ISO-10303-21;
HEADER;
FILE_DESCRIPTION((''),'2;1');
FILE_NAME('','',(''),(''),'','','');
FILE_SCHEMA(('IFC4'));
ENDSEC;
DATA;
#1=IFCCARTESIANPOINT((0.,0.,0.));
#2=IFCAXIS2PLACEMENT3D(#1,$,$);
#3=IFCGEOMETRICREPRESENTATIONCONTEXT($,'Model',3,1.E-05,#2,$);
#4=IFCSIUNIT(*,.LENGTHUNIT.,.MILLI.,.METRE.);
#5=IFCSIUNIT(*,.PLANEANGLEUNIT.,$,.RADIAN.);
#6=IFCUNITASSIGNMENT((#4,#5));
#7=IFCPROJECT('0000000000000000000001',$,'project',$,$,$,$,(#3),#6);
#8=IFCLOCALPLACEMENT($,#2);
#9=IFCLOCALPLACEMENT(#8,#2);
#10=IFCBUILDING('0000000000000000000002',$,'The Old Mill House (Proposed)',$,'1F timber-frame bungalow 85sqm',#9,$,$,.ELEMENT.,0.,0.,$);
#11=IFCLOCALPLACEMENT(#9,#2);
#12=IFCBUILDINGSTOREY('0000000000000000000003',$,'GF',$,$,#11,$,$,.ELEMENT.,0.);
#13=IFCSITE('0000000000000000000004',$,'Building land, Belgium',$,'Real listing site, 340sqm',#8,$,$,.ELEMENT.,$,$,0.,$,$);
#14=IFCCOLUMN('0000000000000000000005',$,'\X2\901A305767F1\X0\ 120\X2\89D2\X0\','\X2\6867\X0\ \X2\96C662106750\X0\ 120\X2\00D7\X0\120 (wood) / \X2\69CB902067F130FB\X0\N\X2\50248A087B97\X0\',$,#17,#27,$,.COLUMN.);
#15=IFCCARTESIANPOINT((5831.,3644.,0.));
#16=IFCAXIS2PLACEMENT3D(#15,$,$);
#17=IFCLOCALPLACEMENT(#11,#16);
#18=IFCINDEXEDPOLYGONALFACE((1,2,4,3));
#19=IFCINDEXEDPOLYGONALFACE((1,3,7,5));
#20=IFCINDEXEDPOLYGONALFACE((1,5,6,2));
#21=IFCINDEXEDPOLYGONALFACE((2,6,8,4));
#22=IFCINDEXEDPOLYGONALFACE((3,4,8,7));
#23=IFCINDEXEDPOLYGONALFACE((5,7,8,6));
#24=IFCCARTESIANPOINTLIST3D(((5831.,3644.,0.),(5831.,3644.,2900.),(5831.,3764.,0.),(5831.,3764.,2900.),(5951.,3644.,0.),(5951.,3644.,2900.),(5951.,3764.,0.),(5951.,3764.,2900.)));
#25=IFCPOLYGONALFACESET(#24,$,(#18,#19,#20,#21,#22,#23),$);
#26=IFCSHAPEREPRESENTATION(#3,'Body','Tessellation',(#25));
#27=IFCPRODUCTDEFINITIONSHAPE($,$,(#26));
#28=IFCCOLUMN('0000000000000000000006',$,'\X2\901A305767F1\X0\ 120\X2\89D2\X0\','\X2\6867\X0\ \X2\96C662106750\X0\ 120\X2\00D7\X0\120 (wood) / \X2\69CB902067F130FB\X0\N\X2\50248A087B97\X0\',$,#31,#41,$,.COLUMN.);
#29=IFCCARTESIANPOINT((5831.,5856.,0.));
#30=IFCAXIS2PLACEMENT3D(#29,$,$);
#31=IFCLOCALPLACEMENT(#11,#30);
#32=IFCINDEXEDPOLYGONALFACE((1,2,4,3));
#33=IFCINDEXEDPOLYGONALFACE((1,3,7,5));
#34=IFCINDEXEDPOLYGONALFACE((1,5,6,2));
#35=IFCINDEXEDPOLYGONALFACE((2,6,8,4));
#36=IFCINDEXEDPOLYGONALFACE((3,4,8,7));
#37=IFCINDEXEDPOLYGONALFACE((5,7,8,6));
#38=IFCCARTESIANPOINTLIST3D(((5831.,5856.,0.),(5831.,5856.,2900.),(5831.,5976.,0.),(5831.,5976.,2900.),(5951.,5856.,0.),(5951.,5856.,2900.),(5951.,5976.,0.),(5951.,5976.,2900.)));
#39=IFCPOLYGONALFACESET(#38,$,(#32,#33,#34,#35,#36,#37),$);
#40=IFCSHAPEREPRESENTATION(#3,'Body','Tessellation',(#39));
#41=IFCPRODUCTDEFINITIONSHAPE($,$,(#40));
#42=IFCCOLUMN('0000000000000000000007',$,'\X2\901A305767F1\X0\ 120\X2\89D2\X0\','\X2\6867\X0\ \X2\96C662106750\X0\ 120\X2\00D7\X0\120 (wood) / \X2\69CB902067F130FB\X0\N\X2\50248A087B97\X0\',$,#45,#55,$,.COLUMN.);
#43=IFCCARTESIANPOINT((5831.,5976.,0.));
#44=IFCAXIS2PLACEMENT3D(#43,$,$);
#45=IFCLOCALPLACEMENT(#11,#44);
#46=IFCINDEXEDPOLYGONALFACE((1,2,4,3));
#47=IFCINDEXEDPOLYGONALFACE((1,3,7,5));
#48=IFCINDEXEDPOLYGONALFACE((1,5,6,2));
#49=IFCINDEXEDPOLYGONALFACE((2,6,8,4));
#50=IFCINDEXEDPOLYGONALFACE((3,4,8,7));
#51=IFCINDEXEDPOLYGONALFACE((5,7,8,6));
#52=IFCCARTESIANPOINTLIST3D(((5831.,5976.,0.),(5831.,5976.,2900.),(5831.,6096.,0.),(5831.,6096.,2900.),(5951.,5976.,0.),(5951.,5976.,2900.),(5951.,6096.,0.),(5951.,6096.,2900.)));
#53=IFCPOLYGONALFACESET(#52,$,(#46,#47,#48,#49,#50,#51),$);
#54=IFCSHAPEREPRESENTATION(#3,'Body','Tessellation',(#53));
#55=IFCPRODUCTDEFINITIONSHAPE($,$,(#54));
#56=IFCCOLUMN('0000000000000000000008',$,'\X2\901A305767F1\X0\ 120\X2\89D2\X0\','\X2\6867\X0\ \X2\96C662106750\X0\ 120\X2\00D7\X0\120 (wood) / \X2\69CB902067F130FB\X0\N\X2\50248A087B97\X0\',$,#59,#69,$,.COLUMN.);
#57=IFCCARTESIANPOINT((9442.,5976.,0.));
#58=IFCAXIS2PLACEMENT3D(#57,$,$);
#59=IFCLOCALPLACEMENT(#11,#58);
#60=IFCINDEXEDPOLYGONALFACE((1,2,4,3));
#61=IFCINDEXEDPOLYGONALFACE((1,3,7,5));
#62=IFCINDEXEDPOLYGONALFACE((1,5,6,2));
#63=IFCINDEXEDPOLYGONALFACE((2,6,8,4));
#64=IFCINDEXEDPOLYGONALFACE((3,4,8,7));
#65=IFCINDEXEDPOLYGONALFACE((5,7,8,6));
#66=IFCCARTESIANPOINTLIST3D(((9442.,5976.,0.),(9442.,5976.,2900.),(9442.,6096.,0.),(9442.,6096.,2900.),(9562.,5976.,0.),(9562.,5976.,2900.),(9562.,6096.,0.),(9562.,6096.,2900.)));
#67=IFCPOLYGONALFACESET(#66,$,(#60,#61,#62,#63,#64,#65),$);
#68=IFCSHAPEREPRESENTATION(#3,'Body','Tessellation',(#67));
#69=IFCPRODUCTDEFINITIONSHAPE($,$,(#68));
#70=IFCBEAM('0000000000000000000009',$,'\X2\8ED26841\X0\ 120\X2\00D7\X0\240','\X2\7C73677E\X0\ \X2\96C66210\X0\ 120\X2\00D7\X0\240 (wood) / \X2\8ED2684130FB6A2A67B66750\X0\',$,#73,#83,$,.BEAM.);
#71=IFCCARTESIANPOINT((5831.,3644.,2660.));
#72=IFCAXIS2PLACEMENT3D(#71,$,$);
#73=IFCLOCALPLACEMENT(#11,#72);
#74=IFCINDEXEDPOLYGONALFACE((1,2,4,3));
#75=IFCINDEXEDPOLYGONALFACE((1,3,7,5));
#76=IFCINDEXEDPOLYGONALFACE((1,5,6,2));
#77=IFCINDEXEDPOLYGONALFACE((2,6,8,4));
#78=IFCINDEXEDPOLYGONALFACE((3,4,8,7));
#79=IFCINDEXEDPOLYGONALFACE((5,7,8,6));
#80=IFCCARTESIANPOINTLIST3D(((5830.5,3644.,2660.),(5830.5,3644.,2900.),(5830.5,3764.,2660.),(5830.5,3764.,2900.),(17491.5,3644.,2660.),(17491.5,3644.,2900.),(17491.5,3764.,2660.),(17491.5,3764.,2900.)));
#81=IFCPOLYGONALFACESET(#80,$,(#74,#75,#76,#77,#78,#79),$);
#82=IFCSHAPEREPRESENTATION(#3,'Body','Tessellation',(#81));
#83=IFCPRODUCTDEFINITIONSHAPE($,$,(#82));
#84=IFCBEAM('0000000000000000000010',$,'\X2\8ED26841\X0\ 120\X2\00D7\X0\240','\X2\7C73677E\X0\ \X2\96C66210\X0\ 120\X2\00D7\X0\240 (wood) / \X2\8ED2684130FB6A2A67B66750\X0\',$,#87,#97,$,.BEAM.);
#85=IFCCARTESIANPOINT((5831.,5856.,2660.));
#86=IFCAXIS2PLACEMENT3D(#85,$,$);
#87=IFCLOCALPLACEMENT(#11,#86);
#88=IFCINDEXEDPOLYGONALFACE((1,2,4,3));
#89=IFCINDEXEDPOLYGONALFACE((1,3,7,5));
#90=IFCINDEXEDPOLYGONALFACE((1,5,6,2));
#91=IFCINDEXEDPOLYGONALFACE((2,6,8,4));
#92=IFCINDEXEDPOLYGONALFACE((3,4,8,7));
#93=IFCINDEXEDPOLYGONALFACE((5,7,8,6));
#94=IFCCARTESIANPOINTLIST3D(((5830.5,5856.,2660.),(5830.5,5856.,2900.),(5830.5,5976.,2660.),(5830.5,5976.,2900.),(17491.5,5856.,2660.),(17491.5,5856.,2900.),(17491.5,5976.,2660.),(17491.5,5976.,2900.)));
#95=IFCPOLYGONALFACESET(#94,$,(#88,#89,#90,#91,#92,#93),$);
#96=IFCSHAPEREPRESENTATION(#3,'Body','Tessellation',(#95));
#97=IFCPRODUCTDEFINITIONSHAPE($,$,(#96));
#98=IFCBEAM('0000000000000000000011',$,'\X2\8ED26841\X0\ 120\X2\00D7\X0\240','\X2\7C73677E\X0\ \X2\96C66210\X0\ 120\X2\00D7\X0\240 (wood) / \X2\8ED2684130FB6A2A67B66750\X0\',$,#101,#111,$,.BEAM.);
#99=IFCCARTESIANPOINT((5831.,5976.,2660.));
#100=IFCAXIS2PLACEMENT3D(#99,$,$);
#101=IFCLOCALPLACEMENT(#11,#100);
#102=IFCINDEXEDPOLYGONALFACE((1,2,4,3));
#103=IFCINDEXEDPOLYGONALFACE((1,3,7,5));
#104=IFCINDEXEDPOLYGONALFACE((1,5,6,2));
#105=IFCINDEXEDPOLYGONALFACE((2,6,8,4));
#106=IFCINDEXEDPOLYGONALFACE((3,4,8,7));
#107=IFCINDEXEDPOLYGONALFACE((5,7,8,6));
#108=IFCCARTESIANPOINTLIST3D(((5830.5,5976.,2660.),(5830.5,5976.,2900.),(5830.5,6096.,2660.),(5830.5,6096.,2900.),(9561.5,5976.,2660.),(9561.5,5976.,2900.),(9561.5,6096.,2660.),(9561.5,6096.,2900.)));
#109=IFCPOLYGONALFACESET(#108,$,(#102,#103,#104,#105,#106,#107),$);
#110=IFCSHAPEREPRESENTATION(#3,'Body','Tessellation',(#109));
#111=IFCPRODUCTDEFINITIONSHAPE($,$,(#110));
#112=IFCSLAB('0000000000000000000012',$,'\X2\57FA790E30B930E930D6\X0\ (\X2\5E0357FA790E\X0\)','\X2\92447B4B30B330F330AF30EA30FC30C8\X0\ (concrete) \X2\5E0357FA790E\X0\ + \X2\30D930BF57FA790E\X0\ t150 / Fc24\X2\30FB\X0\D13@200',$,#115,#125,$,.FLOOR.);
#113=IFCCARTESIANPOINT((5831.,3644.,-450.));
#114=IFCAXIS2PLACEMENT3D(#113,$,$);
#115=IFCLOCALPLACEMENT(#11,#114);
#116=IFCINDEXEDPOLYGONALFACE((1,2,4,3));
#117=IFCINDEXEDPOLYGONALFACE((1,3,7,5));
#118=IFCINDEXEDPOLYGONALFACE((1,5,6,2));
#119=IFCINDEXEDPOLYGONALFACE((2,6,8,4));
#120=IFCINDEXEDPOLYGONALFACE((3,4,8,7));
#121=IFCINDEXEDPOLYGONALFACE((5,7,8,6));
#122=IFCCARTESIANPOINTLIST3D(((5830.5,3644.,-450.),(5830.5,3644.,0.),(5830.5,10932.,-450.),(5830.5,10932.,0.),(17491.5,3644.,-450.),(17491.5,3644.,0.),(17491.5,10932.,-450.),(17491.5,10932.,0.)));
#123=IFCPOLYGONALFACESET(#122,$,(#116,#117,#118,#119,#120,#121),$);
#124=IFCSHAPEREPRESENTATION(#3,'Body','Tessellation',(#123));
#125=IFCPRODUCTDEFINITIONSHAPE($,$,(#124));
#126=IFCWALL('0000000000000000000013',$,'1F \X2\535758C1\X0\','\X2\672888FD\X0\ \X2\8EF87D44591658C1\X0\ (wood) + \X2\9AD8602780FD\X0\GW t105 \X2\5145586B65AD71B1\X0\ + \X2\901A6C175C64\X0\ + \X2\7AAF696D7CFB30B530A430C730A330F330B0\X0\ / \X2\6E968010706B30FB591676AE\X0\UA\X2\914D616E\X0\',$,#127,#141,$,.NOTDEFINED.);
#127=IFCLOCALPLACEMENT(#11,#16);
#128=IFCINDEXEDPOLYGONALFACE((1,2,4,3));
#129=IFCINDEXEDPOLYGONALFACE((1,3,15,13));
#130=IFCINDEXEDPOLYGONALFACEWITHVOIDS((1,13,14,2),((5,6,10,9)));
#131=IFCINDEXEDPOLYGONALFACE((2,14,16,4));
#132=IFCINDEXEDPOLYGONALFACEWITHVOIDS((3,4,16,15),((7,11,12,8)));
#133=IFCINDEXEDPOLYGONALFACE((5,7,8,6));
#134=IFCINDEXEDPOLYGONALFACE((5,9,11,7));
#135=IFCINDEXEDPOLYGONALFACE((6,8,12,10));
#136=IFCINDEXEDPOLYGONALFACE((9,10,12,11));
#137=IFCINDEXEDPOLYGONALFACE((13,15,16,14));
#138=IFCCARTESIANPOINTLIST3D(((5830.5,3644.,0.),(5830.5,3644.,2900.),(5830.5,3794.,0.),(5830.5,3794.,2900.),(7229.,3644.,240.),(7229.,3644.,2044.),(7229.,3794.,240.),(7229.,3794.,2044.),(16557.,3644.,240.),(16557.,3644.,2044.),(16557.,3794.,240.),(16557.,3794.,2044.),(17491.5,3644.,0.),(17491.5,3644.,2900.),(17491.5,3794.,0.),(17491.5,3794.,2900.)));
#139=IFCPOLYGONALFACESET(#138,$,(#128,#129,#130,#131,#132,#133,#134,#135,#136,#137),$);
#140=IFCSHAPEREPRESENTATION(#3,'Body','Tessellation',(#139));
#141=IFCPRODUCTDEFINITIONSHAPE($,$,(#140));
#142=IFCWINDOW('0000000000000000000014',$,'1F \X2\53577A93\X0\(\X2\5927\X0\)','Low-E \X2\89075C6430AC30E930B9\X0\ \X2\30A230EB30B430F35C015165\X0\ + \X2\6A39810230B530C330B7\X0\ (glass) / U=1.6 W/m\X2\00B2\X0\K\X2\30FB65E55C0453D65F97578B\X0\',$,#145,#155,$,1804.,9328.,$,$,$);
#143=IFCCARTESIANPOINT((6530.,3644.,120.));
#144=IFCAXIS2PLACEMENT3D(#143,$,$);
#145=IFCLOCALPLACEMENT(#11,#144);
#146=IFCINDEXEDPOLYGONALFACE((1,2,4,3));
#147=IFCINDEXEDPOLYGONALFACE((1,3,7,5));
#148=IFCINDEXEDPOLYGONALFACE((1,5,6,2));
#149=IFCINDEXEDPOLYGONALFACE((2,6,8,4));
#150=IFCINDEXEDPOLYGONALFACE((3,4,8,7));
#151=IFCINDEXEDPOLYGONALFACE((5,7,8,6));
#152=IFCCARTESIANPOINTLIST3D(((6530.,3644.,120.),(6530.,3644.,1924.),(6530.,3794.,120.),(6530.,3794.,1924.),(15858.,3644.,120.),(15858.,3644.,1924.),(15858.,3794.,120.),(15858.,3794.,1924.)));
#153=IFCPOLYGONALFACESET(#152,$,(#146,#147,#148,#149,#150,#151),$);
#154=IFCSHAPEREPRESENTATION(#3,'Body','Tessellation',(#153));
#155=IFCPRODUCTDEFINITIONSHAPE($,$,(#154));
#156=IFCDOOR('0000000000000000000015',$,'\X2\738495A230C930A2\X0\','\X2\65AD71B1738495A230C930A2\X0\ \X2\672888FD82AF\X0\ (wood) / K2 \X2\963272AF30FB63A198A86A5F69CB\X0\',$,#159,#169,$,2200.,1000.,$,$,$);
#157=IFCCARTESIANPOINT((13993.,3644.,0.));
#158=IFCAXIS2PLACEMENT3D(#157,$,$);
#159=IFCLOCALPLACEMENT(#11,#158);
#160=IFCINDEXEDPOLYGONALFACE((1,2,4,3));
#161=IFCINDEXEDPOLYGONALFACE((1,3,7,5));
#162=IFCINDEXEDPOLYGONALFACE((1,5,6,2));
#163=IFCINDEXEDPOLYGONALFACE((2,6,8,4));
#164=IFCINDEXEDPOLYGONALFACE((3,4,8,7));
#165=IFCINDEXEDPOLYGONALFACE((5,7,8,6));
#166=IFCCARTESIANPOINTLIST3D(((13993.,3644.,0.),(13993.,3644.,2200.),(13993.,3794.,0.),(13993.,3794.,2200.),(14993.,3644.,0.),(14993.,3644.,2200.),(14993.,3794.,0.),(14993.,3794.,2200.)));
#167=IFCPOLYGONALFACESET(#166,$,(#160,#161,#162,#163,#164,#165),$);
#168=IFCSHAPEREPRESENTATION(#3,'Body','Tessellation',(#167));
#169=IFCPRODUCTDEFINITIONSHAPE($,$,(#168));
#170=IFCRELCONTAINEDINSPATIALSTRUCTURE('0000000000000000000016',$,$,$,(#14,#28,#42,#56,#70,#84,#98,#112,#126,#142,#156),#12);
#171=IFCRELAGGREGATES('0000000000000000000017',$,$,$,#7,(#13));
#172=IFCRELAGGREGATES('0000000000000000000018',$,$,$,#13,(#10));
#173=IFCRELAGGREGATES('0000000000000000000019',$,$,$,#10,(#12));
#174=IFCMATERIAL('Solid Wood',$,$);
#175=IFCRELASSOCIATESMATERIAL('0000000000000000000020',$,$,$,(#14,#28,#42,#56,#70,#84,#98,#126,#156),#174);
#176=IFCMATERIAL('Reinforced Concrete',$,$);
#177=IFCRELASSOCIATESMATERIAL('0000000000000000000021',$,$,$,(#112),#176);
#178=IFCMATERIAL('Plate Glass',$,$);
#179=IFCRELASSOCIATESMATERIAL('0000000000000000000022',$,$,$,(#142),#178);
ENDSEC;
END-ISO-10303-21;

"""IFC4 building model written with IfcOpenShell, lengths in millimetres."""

from ifc_helpers import new_model, si_unit, frame, frame_2d, origin, place, context, project, spatial, rectangle, extrude, material, element, fill, save


model = new_model("IFC4")

# Units and contexts
model_context = context("Model", 3, precision=1e-05, world=origin())
ifc_project = project(units=[si_unit("LENGTHUNIT", "METRE", prefix="MILLI"), si_unit("PLANEANGLEUNIT", "RADIAN")], contexts=[model_context])

# Site, building, storey
site_placement = place(None, origin())
site = spatial("IfcSite", under=ifc_project, at=site_placement, Name="Building land, Belgium", ObjectType="Real listing site, 340sqm", CompositionType="ELEMENT", RefElevation=0.0)
building_placement = place(site_placement, origin())
building = spatial("IfcBuilding", under=site, at=building_placement, Name="The Old Mill House (Proposed)", ObjectType="1F timber-frame bungalow 85sqm", CompositionType="ELEMENT", ElevationOfRefHeight=0.0, ElevationOfTerrain=0.0)
storey_placement = place(building_placement, origin())
storey = spatial("IfcBuildingStorey", under=building, at=storey_placement, Name="GF", CompositionType="ELEMENT", Elevation=0.0)

# Columns
ifc_material_1 = material(Name="Solid Wood")
column_1_placement = place(storey_placement, frame((5831.0, 3644.0, 0.0)))
element("IfcColumn", 1, at=column_1_placement, inside=storey, material=ifc_material_1, Name="通し柱 120角", Description="桧 集成材 120×120 (wood) / 構造柱・N値計算", PredefinedType="COLUMN", context=model_context, shape_type="SweptSolid", body=[
    extrude(rectangle(XDim=120.0, YDim=120.0, at=frame_2d((60.0, 60.0))), frame((5831.0, 3644.0, 0.0)), (0.0, 0.0, 1.0), 2900.0),
])
column_2_placement = place(storey_placement, frame((5831.0, 5856.0, 0.0)))
element("IfcColumn", 2, at=column_2_placement, inside=storey, material=ifc_material_1, Name="通し柱 120角", Description="桧 集成材 120×120 (wood) / 構造柱・N値計算", PredefinedType="COLUMN", context=model_context, shape_type="SweptSolid", body=[
    extrude(rectangle(XDim=120.0, YDim=120.0, at=frame_2d((60.0, 60.0))), frame((5831.0, 5856.0, 0.0)), (0.0, 0.0, 1.0), 2900.0),
])
column_3_placement = place(storey_placement, frame((5831.0, 5976.0, 0.0)))
element("IfcColumn", 3, at=column_3_placement, inside=storey, material=ifc_material_1, Name="通し柱 120角", Description="桧 集成材 120×120 (wood) / 構造柱・N値計算", PredefinedType="COLUMN", context=model_context, shape_type="SweptSolid", body=[
    extrude(rectangle(XDim=120.0, YDim=120.0, at=frame_2d((60.0, 60.0))), frame((5831.0, 5976.0, 0.0)), (0.0, 0.0, 1.0), 2900.0),
])
column_4_placement = place(storey_placement, frame((9442.0, 5976.0, 0.0)))
element("IfcColumn", 4, at=column_4_placement, inside=storey, material=ifc_material_1, Name="通し柱 120角", Description="桧 集成材 120×120 (wood) / 構造柱・N値計算", PredefinedType="COLUMN", context=model_context, shape_type="SweptSolid", body=[
    extrude(rectangle(XDim=120.0, YDim=120.0, at=frame_2d((60.0, 60.0))), frame((9442.0, 5976.0, 0.0)), (0.0, 0.0, 1.0), 2900.0),
])

# Beams
beam_1_placement = place(storey_placement, frame((5831.0, 3644.0, 2660.0)))
element("IfcBeam", 5, at=beam_1_placement, inside=storey, material=ifc_material_1, Name="軒桁 120×240", Description="米松 集成 120×240 (wood) / 軒桁・横架材", PredefinedType="BEAM", context=model_context, shape_type="SweptSolid", body=[
    extrude(rectangle(XDim=11661.0, YDim=120.0, at=frame_2d((5830.0, 60.0))), frame((5831.0, 3644.0, 2660.0)), (0.0, 0.0, 1.0), 240.0),
])
beam_2_placement = place(storey_placement, frame((5831.0, 5856.0, 2660.0)))
element("IfcBeam", 6, at=beam_2_placement, inside=storey, material=ifc_material_1, Name="軒桁 120×240", Description="米松 集成 120×240 (wood) / 軒桁・横架材", PredefinedType="BEAM", context=model_context, shape_type="SweptSolid", body=[
    extrude(rectangle(XDim=11661.0, YDim=120.0, at=frame_2d((5830.0, 60.0))), frame((5831.0, 5856.0, 2660.0)), (0.0, 0.0, 1.0), 240.0),
])
beam_3_placement = place(storey_placement, frame((5831.0, 5976.0, 2660.0)))
element("IfcBeam", 7, at=beam_3_placement, inside=storey, material=ifc_material_1, Name="軒桁 120×240", Description="米松 集成 120×240 (wood) / 軒桁・横架材", PredefinedType="BEAM", context=model_context, shape_type="SweptSolid", body=[
    extrude(rectangle(XDim=3731.0, YDim=120.0, at=frame_2d((1865.0, 60.0))), frame((5831.0, 5976.0, 2660.0)), (0.0, 0.0, 1.0), 240.0),
])

# Slab
ifc_material_2 = material(Name="Reinforced Concrete")
slab_1_placement = place(storey_placement, frame((5831.0, 3644.0, -450.0)))
element("IfcSlab", 8, at=slab_1_placement, inside=storey, material=ifc_material_2, Name="基礎スラブ (布基礎)", Description="鉄筋コンクリート (concrete) 布基礎 + ベタ基礎 t150 / Fc24・D13@200", PredefinedType="FLOOR", context=model_context, shape_type="SweptSolid", body=[
    extrude(rectangle(XDim=11661.0, YDim=7288.0, at=frame_2d((5830.0, 3644.0))), frame((5831.0, 3644.0, -450.0)), (0.0, 0.0, 1.0), 450.0),
])

# Wall, openings, window, door
wall_1_placement = place(storey_placement, frame((5831.0, 3644.0, 0.0)))
wall_1 = element("IfcWall", 9, at=wall_1_placement, inside=storey, material=ifc_material_1, Name="1F 南壁", Description="木製 軸組外壁 (wood) + 高性能GW t105 充填断熱 + 通気層 + 窯業系サイディング / 準耐火・外皮UA配慮", PredefinedType="NOTDEFINED", context=model_context, shape_type="SweptSolid", body=[
    extrude(rectangle(XDim=11661.0, YDim=150.0, at=frame_2d((5830.0, 75.0))), frame((5831.0, 3644.0, 0.0)), (0.0, 0.0, 1.0), 2900.0),
])
opening_1_placement = place(storey_placement, frame((6530.0, 3644.0, 120.0)))
opening_1 = element("IfcOpeningElement", 10, at=opening_1_placement, cuts=wall_1, PredefinedType="NOTDEFINED", context=model_context, shape_type="SweptSolid", body=[
    extrude(rectangle(XDim=9328.0, YDim=150.0, at=frame_2d((4664.0, 75.0))), frame((6530.0, 3644.0, 120.0)), (0.0, 0.0, 1.0), 1804.0),
])
opening_2_placement = place(storey_placement, frame((13993.0, 3644.0, 0.0)))
opening_2 = element("IfcOpeningElement", 11, at=opening_2_placement, cuts=wall_1, PredefinedType="NOTDEFINED", context=model_context, shape_type="SweptSolid", body=[
    extrude(rectangle(XDim=1000.0, YDim=150.0, at=frame_2d((500.0, 75.0))), frame((13993.0, 3644.0, 0.0)), (0.0, 0.0, 1.0), 2200.0),
])
ifc_material_3 = material(Name="Plate Glass")
window_1_placement = place(storey_placement, frame((6530.0, 3644.0, 120.0)))
window_1 = element("IfcWindow", 12, at=window_1_placement, inside=storey, material=ifc_material_3, Name="1F 南窓(大)", Description="Low-E 複層ガラス アルゴン封入 + 樹脂サッシ (glass) / U=1.6 W/m²K・日射取得型", OverallHeight=1804.0, OverallWidth=9328.0, context=model_context, shape_type="SweptSolid", body=[
    extrude(rectangle(XDim=9328.0, YDim=150.0, at=frame_2d((4664.0, 75.0))), frame((6530.0, 3644.0, 120.0)), (0.0, 0.0, 1.0), 1804.0),
])
fill(opening_1, window_1)
door_placement = place(storey_placement, frame((13993.0, 3644.0, 0.0)))
door = element("IfcDoor", 13, at=door_placement, inside=storey, material=ifc_material_1, Name="玄関ドア", Description="断熱玄関ドア 木製芯 (wood) / K2 防犯・採風機構", OverallHeight=2200.0, OverallWidth=1000.0, context=model_context, shape_type="SweptSolid", body=[
    extrude(rectangle(XDim=1000.0, YDim=150.0, at=frame_2d((500.0, 75.0))), frame((13993.0, 3644.0, 0.0)), (0.0, 0.0, 1.0), 2200.0),
])
fill(opening_2, door)

save(model, "model.ifc")
